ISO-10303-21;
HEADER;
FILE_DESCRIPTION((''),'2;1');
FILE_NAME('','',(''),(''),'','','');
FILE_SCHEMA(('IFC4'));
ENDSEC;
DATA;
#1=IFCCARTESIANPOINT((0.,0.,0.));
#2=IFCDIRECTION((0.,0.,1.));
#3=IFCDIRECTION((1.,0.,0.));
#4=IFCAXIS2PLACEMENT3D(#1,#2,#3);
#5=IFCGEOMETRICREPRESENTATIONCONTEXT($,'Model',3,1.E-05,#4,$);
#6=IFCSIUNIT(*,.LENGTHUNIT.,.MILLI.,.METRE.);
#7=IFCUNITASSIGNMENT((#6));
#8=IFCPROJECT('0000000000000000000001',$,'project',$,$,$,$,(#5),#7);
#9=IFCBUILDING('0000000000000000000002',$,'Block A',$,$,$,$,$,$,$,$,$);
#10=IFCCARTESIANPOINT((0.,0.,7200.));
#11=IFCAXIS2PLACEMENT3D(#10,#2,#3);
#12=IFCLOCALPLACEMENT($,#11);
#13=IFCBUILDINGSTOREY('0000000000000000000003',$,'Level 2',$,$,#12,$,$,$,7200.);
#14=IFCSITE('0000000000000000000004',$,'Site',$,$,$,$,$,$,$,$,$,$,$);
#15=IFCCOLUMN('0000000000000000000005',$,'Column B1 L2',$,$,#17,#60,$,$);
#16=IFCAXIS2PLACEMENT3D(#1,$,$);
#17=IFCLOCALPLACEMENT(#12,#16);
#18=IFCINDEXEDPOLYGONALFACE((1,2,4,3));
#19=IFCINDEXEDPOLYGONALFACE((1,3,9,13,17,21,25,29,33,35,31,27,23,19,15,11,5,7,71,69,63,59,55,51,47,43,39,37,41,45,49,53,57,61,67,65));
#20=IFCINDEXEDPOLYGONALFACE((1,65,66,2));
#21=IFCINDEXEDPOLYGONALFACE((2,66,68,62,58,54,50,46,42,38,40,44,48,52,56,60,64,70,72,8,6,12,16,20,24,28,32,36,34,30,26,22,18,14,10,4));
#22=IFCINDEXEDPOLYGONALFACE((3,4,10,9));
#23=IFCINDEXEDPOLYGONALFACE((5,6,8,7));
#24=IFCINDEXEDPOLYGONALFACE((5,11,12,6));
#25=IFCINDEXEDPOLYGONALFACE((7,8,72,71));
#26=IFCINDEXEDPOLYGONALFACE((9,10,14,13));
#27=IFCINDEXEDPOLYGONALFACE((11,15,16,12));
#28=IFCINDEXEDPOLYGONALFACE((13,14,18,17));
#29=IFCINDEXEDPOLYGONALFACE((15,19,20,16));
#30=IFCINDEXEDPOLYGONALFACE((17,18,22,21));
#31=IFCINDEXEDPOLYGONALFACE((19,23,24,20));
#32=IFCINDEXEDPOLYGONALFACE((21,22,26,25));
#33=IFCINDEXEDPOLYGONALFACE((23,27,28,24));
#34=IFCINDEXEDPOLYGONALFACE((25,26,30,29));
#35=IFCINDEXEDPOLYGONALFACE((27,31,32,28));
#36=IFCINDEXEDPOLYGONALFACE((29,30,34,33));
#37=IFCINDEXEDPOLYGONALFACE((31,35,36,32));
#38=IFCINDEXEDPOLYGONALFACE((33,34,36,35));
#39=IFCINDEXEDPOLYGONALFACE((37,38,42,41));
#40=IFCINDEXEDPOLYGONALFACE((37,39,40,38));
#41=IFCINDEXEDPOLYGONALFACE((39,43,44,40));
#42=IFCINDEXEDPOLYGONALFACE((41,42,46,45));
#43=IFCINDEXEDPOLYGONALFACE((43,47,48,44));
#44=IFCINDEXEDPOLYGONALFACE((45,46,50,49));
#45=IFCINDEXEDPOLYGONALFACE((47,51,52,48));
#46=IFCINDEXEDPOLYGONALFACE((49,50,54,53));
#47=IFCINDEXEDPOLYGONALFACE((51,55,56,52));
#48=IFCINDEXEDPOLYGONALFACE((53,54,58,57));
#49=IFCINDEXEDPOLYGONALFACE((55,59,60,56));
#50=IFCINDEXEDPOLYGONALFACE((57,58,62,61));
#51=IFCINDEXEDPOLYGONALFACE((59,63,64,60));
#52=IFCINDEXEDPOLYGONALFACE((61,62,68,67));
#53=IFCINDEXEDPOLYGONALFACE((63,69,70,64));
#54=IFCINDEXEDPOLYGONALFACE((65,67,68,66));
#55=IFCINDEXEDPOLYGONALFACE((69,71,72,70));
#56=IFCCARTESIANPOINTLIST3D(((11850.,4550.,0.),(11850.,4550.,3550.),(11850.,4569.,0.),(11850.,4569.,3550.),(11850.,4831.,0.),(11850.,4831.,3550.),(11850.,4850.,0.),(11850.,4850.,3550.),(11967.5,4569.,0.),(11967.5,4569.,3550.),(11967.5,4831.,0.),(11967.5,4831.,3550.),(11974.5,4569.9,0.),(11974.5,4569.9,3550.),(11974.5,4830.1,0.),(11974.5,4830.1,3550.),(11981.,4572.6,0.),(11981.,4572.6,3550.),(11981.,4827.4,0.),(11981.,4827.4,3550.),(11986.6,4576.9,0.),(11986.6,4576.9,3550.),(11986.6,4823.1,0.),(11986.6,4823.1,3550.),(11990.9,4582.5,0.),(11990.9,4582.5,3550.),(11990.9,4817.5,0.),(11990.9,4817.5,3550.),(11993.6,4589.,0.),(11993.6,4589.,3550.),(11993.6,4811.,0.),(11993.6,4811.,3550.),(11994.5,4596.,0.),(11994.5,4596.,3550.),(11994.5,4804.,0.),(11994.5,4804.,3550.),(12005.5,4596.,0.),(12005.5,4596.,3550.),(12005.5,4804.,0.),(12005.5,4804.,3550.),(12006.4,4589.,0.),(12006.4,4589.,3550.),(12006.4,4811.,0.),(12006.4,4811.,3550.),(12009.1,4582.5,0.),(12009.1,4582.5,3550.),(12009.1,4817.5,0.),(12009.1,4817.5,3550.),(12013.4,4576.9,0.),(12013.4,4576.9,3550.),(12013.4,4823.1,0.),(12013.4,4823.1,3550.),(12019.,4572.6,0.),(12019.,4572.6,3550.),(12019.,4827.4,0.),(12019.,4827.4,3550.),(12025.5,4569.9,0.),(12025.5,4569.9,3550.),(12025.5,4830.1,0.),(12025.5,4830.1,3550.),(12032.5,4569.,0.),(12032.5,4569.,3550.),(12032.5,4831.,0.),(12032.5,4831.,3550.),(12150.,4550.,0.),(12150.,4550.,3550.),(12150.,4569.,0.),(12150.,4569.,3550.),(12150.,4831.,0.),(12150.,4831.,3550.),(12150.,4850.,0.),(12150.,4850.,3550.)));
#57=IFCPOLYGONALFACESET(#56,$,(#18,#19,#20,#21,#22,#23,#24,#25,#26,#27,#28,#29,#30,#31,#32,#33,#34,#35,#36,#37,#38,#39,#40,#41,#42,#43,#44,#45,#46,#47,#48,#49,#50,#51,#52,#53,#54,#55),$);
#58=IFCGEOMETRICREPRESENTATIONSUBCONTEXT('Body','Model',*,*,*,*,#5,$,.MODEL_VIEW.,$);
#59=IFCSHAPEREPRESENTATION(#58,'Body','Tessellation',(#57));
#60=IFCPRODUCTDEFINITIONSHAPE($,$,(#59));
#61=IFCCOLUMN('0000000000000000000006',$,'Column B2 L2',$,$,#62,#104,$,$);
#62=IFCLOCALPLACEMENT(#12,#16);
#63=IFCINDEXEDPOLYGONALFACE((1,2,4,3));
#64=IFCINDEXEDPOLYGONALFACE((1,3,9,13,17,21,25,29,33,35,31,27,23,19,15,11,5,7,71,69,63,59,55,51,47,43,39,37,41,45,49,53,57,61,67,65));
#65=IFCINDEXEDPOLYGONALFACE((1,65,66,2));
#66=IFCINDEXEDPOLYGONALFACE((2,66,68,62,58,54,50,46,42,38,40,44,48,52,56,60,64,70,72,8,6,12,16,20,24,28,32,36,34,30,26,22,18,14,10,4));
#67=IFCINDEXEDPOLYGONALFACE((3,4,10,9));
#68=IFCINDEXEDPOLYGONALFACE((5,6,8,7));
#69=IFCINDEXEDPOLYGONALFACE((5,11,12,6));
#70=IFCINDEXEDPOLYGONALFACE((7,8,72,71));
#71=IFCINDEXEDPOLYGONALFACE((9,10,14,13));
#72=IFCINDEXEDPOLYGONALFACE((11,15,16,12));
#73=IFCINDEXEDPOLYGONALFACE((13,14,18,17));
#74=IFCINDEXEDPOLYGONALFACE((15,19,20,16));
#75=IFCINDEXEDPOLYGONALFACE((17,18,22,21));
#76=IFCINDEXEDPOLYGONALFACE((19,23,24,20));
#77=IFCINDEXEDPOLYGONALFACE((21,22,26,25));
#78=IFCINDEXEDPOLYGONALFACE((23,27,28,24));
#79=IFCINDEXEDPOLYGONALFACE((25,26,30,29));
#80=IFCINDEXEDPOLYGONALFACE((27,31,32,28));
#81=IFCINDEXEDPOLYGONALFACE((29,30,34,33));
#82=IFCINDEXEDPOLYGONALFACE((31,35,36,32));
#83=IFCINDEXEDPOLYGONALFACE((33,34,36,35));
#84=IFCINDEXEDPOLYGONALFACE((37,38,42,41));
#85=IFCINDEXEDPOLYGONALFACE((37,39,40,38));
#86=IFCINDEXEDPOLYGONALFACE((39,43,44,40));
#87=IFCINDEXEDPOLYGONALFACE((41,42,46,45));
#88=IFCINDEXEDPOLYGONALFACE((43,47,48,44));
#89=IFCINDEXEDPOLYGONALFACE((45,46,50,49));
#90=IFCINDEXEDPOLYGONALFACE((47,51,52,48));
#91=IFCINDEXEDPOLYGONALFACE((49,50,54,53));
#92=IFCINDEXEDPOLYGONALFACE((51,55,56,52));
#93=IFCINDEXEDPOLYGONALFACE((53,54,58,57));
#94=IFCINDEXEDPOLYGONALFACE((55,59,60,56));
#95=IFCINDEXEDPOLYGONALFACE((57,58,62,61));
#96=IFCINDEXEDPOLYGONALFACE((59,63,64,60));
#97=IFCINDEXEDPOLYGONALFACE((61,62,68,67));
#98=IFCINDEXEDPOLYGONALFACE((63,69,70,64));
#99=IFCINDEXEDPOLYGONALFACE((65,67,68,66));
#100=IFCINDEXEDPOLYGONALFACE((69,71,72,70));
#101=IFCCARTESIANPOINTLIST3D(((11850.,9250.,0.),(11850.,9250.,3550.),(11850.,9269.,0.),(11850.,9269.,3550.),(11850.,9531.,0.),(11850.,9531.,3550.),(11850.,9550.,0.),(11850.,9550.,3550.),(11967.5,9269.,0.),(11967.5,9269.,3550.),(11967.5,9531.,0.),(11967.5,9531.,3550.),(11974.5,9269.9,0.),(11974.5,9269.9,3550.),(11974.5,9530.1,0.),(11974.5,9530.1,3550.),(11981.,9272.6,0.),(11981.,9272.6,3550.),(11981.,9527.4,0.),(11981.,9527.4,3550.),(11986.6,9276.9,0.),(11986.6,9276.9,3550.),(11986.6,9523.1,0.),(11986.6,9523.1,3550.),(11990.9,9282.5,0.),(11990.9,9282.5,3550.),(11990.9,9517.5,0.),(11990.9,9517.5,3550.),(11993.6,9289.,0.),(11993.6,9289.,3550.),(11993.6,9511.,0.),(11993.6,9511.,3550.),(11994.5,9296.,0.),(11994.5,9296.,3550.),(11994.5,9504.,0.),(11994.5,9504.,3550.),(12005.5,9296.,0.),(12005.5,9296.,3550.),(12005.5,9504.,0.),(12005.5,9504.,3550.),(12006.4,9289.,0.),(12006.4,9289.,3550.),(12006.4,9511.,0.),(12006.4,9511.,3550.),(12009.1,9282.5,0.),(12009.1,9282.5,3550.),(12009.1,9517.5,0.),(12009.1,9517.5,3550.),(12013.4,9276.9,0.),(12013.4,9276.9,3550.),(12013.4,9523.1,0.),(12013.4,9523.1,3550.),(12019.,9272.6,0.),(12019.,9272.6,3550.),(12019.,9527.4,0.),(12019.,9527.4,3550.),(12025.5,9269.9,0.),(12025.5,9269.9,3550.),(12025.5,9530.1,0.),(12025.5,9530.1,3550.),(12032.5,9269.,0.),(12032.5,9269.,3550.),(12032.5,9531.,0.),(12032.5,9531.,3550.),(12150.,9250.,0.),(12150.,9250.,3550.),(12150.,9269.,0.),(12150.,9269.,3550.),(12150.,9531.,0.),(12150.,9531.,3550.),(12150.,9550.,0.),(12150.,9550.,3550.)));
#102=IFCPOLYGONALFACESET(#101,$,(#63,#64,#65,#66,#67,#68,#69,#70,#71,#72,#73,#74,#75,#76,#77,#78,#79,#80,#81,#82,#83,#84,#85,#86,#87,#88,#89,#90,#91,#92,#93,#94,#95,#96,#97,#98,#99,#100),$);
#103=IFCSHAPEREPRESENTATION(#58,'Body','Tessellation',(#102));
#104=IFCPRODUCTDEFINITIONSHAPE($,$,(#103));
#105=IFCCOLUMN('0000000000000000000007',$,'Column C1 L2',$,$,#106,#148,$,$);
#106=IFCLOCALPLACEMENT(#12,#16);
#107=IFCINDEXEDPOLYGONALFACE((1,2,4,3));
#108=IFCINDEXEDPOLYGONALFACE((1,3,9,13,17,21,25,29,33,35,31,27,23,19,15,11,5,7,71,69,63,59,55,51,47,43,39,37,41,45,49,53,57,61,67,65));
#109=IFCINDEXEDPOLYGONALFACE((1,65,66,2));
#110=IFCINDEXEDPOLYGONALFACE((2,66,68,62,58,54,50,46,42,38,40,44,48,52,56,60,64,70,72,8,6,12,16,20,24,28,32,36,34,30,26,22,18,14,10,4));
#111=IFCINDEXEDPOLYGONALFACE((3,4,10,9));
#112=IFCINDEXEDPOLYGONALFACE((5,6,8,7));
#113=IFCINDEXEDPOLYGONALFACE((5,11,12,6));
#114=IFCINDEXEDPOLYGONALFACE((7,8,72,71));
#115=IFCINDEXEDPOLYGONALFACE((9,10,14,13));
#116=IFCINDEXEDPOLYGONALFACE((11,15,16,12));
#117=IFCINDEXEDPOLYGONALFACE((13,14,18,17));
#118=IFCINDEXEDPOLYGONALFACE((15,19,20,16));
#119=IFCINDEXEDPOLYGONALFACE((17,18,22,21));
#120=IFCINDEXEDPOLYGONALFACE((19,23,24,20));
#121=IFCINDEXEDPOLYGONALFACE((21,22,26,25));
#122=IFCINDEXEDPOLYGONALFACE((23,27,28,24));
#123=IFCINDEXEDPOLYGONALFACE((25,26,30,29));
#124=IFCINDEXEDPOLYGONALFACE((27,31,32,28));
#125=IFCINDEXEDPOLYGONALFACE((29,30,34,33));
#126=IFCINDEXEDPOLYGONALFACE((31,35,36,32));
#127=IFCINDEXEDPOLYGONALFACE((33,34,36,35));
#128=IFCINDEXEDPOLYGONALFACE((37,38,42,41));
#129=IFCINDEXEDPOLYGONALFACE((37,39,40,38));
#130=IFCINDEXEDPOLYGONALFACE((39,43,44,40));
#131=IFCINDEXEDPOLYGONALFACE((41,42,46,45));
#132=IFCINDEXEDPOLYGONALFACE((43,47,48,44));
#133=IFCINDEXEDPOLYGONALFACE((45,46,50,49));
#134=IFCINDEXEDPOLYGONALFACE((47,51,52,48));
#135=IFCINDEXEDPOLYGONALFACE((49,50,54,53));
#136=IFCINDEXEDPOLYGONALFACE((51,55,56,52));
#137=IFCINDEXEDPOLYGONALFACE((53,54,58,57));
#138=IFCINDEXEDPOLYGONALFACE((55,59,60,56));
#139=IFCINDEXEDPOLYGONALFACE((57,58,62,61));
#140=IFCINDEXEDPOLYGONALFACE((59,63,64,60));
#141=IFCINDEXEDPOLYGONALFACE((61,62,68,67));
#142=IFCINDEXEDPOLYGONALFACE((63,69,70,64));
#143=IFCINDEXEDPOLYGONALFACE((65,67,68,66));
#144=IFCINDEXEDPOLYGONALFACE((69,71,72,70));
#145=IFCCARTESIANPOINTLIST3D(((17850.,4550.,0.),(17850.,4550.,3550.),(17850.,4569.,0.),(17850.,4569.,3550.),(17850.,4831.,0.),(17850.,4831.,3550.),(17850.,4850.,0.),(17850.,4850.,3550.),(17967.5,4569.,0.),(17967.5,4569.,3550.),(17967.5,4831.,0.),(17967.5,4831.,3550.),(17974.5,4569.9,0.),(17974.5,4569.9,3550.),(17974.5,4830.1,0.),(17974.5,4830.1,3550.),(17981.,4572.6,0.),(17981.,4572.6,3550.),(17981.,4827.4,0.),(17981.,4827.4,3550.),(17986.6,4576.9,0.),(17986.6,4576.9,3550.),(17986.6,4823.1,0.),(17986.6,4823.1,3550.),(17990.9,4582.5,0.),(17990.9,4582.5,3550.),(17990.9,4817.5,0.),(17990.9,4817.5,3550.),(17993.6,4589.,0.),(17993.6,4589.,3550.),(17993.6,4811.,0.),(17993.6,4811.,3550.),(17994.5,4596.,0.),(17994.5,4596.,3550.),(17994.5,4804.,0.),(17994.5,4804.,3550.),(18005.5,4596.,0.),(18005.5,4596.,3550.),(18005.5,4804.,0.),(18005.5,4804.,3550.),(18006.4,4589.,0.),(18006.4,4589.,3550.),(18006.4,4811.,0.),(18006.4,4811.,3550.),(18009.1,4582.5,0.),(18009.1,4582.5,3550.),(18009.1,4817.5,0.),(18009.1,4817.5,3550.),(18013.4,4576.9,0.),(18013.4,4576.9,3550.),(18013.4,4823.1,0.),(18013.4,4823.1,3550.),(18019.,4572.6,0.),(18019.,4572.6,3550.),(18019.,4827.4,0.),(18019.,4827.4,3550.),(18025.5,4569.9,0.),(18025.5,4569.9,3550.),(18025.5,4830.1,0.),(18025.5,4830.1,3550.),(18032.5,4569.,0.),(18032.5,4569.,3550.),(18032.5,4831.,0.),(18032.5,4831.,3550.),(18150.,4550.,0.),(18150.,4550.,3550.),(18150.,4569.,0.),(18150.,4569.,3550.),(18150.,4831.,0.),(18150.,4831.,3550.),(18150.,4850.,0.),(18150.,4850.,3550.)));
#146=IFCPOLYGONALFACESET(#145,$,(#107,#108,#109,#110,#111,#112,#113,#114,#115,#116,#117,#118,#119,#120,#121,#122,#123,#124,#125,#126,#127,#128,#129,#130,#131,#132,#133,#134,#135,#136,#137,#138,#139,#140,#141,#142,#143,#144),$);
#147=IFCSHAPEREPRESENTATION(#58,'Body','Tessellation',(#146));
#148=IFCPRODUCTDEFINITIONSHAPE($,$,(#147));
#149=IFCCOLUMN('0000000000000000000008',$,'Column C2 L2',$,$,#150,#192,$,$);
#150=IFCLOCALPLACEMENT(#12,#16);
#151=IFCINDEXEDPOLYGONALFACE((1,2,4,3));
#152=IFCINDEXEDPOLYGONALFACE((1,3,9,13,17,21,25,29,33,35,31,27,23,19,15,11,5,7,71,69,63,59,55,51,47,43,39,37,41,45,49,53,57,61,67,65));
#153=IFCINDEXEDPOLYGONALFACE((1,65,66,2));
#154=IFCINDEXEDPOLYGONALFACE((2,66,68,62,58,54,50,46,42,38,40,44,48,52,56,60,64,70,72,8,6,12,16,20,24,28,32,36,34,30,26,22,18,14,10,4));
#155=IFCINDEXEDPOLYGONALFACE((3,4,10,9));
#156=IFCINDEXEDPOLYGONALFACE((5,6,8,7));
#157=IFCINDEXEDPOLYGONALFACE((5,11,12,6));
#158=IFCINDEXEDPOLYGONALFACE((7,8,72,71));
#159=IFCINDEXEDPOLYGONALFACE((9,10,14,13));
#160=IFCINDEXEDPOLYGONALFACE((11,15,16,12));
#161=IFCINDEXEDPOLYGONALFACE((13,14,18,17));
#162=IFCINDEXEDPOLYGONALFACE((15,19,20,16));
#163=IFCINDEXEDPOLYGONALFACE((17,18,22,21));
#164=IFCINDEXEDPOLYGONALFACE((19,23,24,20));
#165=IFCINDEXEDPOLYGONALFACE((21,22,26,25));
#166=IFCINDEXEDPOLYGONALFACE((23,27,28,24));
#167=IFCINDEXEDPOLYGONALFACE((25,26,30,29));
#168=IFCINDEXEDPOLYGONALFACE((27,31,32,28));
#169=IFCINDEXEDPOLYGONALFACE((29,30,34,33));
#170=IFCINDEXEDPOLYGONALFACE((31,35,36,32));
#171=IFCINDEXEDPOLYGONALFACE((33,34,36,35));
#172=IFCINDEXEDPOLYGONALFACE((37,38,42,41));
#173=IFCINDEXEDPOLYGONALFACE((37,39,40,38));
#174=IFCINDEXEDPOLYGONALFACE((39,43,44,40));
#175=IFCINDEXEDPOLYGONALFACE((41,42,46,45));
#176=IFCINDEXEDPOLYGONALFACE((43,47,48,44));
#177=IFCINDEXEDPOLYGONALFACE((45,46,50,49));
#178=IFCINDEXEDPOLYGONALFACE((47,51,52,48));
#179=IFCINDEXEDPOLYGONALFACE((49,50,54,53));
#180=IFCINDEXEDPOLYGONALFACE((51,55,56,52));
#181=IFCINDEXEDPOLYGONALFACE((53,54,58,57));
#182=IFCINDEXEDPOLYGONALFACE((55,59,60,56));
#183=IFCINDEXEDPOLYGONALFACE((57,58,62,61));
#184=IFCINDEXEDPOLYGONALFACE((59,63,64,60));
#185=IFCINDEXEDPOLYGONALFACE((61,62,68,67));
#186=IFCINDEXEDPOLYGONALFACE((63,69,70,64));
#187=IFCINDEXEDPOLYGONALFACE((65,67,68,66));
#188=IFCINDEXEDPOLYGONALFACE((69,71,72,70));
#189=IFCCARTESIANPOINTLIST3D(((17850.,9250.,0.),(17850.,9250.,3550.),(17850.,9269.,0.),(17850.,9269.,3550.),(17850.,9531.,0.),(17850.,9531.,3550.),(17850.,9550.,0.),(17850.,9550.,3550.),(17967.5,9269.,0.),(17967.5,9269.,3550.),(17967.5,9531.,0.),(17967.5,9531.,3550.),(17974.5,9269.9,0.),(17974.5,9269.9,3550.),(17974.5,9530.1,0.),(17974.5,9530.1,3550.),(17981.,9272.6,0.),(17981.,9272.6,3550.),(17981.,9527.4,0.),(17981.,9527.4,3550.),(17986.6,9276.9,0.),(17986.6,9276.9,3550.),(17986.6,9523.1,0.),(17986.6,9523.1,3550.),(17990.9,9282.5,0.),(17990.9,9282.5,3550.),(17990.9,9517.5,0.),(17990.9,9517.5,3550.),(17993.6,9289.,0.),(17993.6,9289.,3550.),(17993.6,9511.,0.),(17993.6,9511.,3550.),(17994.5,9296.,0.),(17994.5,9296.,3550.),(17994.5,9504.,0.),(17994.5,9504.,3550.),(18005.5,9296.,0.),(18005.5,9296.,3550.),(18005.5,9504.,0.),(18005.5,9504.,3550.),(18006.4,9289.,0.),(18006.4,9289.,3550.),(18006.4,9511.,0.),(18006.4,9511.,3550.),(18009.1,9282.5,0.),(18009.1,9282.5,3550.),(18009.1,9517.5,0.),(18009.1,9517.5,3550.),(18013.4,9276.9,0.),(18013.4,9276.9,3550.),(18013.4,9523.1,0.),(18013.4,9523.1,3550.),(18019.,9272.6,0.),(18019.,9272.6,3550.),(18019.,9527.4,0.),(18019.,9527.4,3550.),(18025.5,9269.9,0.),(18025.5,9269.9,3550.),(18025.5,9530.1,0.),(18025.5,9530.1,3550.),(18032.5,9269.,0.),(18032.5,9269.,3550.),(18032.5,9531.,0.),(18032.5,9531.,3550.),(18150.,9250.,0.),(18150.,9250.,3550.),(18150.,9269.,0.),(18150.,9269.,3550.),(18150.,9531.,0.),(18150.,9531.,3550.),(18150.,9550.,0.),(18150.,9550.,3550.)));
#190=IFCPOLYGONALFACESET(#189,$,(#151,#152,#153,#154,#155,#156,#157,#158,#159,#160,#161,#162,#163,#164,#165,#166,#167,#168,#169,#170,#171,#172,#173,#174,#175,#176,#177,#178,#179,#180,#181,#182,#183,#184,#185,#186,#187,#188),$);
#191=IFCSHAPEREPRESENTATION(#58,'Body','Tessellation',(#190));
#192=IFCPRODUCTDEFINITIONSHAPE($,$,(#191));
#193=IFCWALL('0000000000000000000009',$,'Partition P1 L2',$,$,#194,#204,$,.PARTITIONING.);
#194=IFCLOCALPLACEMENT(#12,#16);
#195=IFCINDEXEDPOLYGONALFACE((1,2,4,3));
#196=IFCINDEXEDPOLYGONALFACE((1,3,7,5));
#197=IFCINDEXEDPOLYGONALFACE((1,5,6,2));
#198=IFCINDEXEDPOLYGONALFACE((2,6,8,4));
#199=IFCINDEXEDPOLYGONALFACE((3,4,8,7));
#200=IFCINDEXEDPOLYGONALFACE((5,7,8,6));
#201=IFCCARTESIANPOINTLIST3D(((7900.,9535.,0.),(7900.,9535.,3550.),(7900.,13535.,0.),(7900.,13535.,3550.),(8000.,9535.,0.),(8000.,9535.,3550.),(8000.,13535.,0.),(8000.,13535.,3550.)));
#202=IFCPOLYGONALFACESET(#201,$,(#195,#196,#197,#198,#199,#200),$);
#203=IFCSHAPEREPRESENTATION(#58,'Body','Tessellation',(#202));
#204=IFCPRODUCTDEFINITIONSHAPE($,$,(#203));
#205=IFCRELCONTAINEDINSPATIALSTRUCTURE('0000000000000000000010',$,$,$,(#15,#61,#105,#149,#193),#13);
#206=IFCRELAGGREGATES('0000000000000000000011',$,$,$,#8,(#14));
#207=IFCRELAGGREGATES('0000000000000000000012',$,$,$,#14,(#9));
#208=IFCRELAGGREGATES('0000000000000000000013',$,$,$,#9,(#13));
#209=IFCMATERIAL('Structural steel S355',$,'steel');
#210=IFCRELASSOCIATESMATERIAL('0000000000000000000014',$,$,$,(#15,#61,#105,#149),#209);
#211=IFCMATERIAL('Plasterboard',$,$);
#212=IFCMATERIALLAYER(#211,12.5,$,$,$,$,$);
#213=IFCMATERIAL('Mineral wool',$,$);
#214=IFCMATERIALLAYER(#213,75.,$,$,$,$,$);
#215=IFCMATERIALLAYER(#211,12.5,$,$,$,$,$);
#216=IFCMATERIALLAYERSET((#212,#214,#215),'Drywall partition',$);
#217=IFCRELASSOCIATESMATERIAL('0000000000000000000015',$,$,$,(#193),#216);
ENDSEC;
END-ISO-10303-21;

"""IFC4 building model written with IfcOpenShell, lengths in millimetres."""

from ifc_helpers import new_model, si_unit, frame, origin_with_axes, place, context, subcontext, project, spatial, indexed_curve, i_section, outline, extrude, material, layer, layer_set, layer_usage, material_profile, profile_set, element, save


model = new_model("IFC4")

# Units and contexts
model_context = context("Model", 3, precision=1e-05, world=origin_with_axes())
body_context = subcontext(model_context, "Body", "Model", "MODEL_VIEW")
ifc_project = project(units=[si_unit("LENGTHUNIT", "METRE", prefix="MILLI")], contexts=[model_context])

# Site, building, storey
site = spatial("IfcSite", under=ifc_project, Name="Site")
building = spatial("IfcBuilding", under=site, Name="Block A")
storey_placement = place(None, frame((0.0, 0.0, 7200.0), z_axis=(0.0, 0.0, 1.0), x_axis=(1.0, 0.0, 0.0)))
storey = spatial("IfcBuildingStorey", under=building, at=storey_placement, Name="Level 2", Elevation=7200.0)

# Columns
ifc_material_1 = material(Name="Structural steel S355", Category="steel")
ifc_material_profile = material_profile(ifc_material_1, i_section(OverallWidth=300.0, OverallDepth=300.0, WebThickness=11.0, FlangeThickness=19.0, FilletRadius=27.0))
ifc_profile_set = profile_set([ifc_material_profile], Name="HEB 300")
for number, where, z_axis, x_axis, name in (
    (1, (12000.0, 4700.0, 0.0), (0.0, 0.0, 1.0), (1.0, 0.0, 0.0), "Column B1 L2"),
    (2, (12000.0, 9400.0, 0.0), (0.0, 0.0, 1.0), (1.0, 0.0, 0.0), "Column B2 L2"),
    (3, (18000.0, 4700.0, 0.0), (0.0, 0.0, 1.0), (1.0, 0.0, 0.0), "Column C1 L2"),
    (4, (18000.0, 9400.0, 0.0), (0.0, 0.0, 1.0), (1.0, 0.0, 0.0), "Column C2 L2"),
):
    element("IfcColumn", number, at=place(storey_placement, frame(where, z_axis=z_axis, x_axis=x_axis)), inside=storey, material=ifc_profile_set, Name=name, context=body_context, shape_type="SweptSolid", body=[
        extrude(i_section(OverallWidth=300.0, OverallDepth=300.0, WebThickness=11.0, FlangeThickness=19.0, FilletRadius=27.0), origin_with_axes(), (0.0, 0.0, 1.0), 3550.0),
    ])

# Shared definitions
ifc_material_2 = material(Name="Mineral wool")

# Wall
ifc_material_3 = material(Name="Plasterboard")
ifc_layer_1 = layer(ifc_material_3, 12.5)
ifc_layer_2 = layer(ifc_material_2, 75.0)
ifc_layer_3 = layer(ifc_material_3, 12.5)
ifc_layer_set_1 = layer_set([ifc_layer_1, ifc_layer_2, ifc_layer_3], Name="Drywall partition")
ifc_layer_usage_1 = layer_usage(ifc_layer_set_1, "AXIS2", "POSITIVE", 0.0)
wall_1_placement = place(storey_placement, frame((8000.0, 9535.0, 0.0), z_axis=(0.0, 0.0, 1.0), x_axis=(0.0, 1.0, 0.0)))
element("IfcWall", 5, at=wall_1_placement, inside=storey, material=ifc_layer_usage_1, Name="Partition P1 L2", PredefinedType="PARTITIONING", context=body_context, shape_type="SweptSolid", body=[
    extrude(outline(indexed_curve([(0.0, 0.0), (0.0, 100.0), (4000.0, 100.0), (4000.0, 0.0), (0.0, 0.0)], self_intersect=False)), origin_with_axes(), (0.0, 0.0, 1.0), 3550.0),
])

save(model, "model.ifc")
